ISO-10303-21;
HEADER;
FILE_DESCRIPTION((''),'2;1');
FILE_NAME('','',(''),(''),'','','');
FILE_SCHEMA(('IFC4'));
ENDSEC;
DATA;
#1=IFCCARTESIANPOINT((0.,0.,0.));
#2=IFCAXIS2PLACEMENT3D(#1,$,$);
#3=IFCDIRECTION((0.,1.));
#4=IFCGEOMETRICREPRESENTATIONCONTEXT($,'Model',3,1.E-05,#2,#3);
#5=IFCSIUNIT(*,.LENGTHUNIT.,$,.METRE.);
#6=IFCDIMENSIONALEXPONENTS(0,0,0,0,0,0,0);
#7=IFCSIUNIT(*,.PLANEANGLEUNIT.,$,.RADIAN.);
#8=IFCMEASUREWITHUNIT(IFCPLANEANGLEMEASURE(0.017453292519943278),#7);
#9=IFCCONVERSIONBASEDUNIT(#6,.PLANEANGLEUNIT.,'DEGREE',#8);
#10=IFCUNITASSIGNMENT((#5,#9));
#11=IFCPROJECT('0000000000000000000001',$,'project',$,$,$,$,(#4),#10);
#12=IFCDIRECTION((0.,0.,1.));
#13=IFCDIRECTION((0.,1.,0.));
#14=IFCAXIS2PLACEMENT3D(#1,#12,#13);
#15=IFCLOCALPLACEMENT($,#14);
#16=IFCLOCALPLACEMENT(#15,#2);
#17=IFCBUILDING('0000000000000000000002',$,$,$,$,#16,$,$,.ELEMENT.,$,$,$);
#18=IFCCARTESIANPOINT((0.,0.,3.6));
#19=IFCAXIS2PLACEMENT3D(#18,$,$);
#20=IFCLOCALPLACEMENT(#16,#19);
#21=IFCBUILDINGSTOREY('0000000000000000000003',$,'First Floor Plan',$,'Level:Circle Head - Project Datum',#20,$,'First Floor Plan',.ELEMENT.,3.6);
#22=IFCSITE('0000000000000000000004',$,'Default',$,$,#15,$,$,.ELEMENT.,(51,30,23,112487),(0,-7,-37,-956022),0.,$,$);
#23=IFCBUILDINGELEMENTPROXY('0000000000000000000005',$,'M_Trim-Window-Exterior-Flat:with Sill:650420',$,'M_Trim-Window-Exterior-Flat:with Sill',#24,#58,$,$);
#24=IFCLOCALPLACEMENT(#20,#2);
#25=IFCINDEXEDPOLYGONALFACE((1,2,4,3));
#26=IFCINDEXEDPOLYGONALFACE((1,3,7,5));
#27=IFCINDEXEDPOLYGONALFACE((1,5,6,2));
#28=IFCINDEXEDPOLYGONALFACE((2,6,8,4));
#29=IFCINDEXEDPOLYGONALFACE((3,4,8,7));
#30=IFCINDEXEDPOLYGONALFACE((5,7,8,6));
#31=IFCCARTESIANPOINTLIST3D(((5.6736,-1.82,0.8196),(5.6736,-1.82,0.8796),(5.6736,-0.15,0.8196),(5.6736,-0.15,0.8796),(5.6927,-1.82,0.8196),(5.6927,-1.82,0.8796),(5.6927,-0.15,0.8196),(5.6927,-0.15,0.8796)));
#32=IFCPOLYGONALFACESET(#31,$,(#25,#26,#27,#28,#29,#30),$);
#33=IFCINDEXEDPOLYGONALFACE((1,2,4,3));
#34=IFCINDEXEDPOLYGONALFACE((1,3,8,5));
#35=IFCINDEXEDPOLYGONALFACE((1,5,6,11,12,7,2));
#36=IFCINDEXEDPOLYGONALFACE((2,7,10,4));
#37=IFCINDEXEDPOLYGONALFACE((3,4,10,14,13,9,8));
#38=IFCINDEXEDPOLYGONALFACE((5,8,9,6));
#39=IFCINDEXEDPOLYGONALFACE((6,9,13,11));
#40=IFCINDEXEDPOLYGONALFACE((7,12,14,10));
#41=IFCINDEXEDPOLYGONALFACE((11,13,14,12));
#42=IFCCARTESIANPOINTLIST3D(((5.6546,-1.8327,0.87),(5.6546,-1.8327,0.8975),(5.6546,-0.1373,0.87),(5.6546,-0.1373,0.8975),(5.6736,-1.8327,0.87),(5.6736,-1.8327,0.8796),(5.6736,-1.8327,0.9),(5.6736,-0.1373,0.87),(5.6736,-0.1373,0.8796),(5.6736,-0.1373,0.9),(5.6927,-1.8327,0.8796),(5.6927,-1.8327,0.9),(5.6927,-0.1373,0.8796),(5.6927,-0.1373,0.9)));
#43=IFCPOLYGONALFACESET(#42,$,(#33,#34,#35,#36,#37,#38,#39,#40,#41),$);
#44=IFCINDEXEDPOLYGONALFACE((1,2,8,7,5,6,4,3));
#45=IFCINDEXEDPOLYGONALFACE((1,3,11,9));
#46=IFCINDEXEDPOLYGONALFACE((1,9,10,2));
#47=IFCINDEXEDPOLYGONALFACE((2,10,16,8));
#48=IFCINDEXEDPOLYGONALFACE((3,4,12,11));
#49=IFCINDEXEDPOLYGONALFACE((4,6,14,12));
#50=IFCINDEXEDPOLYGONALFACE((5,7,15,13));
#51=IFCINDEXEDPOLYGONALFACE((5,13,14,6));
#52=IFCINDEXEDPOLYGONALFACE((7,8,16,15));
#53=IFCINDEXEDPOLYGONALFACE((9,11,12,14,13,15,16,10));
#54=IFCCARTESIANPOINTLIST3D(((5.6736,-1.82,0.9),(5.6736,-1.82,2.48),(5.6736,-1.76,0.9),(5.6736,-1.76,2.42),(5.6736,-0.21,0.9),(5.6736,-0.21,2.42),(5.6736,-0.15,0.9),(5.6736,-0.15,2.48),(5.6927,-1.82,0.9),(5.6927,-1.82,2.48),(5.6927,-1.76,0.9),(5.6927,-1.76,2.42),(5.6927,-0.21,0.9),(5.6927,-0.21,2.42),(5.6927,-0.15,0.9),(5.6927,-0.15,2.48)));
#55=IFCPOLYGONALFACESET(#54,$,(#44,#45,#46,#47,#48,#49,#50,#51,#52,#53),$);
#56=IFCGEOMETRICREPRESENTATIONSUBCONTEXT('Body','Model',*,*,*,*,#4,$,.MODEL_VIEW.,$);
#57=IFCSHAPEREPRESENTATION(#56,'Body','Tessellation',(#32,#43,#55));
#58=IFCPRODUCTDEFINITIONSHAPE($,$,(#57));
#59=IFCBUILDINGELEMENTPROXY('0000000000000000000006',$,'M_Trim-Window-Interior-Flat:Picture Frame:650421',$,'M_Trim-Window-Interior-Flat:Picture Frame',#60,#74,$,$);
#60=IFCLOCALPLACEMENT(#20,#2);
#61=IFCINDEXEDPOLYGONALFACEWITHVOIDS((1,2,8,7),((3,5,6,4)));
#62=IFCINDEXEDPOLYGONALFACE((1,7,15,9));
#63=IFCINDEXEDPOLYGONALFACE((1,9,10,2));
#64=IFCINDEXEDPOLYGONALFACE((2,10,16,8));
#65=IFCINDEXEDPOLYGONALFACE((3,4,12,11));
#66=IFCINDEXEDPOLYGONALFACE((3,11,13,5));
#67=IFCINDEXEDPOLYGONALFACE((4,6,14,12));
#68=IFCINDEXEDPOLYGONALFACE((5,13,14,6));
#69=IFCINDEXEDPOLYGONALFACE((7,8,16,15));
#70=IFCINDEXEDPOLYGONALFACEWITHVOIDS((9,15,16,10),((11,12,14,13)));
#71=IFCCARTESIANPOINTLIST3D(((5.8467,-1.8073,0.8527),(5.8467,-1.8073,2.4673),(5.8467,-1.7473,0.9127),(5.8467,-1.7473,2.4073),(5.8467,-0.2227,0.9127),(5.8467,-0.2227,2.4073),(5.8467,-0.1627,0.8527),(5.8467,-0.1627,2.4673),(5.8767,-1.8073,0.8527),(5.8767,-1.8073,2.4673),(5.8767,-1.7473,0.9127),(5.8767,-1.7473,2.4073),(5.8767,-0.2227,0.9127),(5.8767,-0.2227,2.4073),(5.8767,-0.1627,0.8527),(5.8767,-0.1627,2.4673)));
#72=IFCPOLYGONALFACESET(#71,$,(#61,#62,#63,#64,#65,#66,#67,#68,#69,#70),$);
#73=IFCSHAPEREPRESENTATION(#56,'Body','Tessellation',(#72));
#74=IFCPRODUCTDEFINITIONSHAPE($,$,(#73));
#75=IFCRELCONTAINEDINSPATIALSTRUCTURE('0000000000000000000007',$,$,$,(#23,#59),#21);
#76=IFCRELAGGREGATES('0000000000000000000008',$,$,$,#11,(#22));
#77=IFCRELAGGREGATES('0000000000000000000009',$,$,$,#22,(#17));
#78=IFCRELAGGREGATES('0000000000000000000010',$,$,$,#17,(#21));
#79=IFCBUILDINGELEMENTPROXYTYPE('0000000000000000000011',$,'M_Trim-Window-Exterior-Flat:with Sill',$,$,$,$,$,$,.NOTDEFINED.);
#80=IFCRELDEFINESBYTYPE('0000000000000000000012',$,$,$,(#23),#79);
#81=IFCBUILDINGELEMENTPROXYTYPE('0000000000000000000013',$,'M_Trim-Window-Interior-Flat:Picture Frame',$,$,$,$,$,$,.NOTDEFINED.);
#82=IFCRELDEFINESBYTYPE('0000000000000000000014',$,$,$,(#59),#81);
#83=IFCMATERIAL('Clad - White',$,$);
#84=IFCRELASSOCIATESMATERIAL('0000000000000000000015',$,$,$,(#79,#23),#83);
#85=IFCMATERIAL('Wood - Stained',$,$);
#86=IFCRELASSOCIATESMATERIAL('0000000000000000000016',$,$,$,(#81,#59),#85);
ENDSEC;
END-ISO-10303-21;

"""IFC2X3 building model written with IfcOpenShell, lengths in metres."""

from ifc_helpers import new_model, entity, si_unit, converted_unit, direction, frame, frame_2d, origin, place, context, subcontext, project, spatial, polyline, rectangle, outline, extrude, source, transform, mapped, material, type_object, type_shapes, element, save


model = new_model("IFC2X3")

# Units and contexts
model_context = context("Model", 3, precision=1e-05, world=origin(), true_north=direction((0.0, 1.0)))
body_context = subcontext(model_context, "Body", "Model", "MODEL_VIEW")
ifc_project = project(units=[si_unit("LENGTHUNIT", "METRE"), converted_unit("PLANEANGLEUNIT", "DEGREE", entity("IfcPlaneAngleMeasure", 0.017453292519943278), si_unit("PLANEANGLEUNIT", "RADIAN"), dimensions=[0, 0, 0, 0, 0, 0, 0])], contexts=[model_context])

# Site, building, storey
site_placement = place(None, frame((0.0, 0.0, 0.0), z_axis=(0.0, 0.0, 1.0), x_axis=(0.0, 1.0, 0.0)))
site = spatial("IfcSite", under=ifc_project, at=site_placement, Name="Default", CompositionType="ELEMENT", RefLatitude=(51, 30, 23, 112487), RefLongitude=(0, -7, -37, -956022), RefElevation=0.0)
building_placement = place(site_placement, origin())
building = spatial("IfcBuilding", under=site, at=building_placement, CompositionType="ELEMENT")
storey_placement = place(building_placement, frame((0.0, 0.0, 3.6)))
storey = spatial("IfcBuildingStorey", under=building, at=storey_placement, Name="First Floor Plan", ObjectType="Level:Circle Head - Project Datum", LongName="First Floor Plan", CompositionType="ELEMENT", Elevation=3.6)

# Building element proxies
ifc_material_1 = material(Name="Clad - White")
ifc_material_2 = material(Name="Wood - Stained")
building_element_proxy_type_1 = type_object("IfcBuildingElementProxyType", Name="M_Trim-Window-Exterior-Flat:with Sill", PredefinedType="NOTDEFINED", material=ifc_material_1)
shared_shape_1 = source(origin(), body_context, "Body", "SweptSolid", [
    extrude(rectangle(XDim=1.67, YDim=0.06, at=frame_2d((0.0, 0.0), x_axis=(1.0, 0.0))), frame((0.0, -1.5704, 0.0), z_axis=(0.0, 0.0, 1.0), x_axis=(-1.0, 0.0, 0.0)), (0.0, 0.0, 1.0), 0.019),
    extrude(outline(polyline([(-0.019, -0.0152), (0.0, -0.0152), (0.0, -0.0057), (0.019, -0.0057), (0.019, 0.0148), (0.0, 0.0148), (-0.019, 0.0123), (-0.019, -0.0152)])), frame((-0.8477, -1.5348, 0.019), z_axis=(1.0, 0.0, 0.0), x_axis=(0.0, 0.0, -1.0)), (0.0, 0.0, 1.0), 1.6954),
    extrude(outline(polyline([(-0.805, -0.835), (0.775, -0.835), (0.775, -0.775), (-0.745, -0.775), (-0.745, 0.775), (0.775, 0.775), (0.775, 0.835), (-0.805, 0.835), (-0.805, -0.835)])), frame((0.0, -0.745, 0.0), z_axis=(0.0, 0.0, 1.0), x_axis=(0.0, -1.0, 0.0)), (0.0, 0.0, 1.0), 0.019),
])
type_shapes(building_element_proxy_type_1, [shared_shape_1])
proxy_1_placement = place(storey_placement, frame((5.6927, -0.985, 2.42), z_axis=(-1.0, 0.0, 0.0), x_axis=(0.0, -1.0, 0.0)))
element("IfcBuildingElementProxy", 1, at=proxy_1_placement, inside=storey, type_object=building_element_proxy_type_1, material=ifc_material_1, Name="M_Trim-Window-Exterior-Flat:with Sill:650420", ObjectType="M_Trim-Window-Exterior-Flat:with Sill", context=body_context, shape_type="MappedRepresentation", body=[
    mapped(shared_shape_1, transform((0.0, 0.0, 0.0), scale=1.0)),
])
building_element_proxy_type_2 = type_object("IfcBuildingElementProxyType", Name="M_Trim-Window-Interior-Flat:Picture Frame", PredefinedType="NOTDEFINED", material=ifc_material_2)
shared_shape_2 = source(origin(), body_context, "Body", "SweptSolid", [
    extrude(outline(polyline([(-0.8223, -0.8073), (0.8223, -0.8073), (0.8223, 0.8073), (-0.8223, 0.8073), (-0.8223, -0.8073)]), holes=[polyline([(-0.7623, -0.7473), (-0.7623, 0.7473), (0.7623, 0.7473), (0.7623, -0.7473), (-0.7623, -0.7473)])]), frame((0.0, -0.76, 0.0), z_axis=(0.0, 0.0, 1.0), x_axis=(-1.0, 0.0, 0.0)), (0.0, 0.0, 1.0), 0.03),
])
type_shapes(building_element_proxy_type_2, [shared_shape_2])
proxy_2_placement = place(storey_placement, frame((5.8467, -0.985, 2.42), z_axis=(1.0, 0.0, 0.0), x_axis=(0.0, 1.0, 0.0)))
element("IfcBuildingElementProxy", 2, at=proxy_2_placement, inside=storey, type_object=building_element_proxy_type_2, material=ifc_material_2, Name="M_Trim-Window-Interior-Flat:Picture Frame:650421", ObjectType="M_Trim-Window-Interior-Flat:Picture Frame", context=body_context, shape_type="MappedRepresentation", body=[
    mapped(shared_shape_2, transform((0.0, 0.0, 0.0), scale=1.0)),
])

save(model, "model.ifc")
